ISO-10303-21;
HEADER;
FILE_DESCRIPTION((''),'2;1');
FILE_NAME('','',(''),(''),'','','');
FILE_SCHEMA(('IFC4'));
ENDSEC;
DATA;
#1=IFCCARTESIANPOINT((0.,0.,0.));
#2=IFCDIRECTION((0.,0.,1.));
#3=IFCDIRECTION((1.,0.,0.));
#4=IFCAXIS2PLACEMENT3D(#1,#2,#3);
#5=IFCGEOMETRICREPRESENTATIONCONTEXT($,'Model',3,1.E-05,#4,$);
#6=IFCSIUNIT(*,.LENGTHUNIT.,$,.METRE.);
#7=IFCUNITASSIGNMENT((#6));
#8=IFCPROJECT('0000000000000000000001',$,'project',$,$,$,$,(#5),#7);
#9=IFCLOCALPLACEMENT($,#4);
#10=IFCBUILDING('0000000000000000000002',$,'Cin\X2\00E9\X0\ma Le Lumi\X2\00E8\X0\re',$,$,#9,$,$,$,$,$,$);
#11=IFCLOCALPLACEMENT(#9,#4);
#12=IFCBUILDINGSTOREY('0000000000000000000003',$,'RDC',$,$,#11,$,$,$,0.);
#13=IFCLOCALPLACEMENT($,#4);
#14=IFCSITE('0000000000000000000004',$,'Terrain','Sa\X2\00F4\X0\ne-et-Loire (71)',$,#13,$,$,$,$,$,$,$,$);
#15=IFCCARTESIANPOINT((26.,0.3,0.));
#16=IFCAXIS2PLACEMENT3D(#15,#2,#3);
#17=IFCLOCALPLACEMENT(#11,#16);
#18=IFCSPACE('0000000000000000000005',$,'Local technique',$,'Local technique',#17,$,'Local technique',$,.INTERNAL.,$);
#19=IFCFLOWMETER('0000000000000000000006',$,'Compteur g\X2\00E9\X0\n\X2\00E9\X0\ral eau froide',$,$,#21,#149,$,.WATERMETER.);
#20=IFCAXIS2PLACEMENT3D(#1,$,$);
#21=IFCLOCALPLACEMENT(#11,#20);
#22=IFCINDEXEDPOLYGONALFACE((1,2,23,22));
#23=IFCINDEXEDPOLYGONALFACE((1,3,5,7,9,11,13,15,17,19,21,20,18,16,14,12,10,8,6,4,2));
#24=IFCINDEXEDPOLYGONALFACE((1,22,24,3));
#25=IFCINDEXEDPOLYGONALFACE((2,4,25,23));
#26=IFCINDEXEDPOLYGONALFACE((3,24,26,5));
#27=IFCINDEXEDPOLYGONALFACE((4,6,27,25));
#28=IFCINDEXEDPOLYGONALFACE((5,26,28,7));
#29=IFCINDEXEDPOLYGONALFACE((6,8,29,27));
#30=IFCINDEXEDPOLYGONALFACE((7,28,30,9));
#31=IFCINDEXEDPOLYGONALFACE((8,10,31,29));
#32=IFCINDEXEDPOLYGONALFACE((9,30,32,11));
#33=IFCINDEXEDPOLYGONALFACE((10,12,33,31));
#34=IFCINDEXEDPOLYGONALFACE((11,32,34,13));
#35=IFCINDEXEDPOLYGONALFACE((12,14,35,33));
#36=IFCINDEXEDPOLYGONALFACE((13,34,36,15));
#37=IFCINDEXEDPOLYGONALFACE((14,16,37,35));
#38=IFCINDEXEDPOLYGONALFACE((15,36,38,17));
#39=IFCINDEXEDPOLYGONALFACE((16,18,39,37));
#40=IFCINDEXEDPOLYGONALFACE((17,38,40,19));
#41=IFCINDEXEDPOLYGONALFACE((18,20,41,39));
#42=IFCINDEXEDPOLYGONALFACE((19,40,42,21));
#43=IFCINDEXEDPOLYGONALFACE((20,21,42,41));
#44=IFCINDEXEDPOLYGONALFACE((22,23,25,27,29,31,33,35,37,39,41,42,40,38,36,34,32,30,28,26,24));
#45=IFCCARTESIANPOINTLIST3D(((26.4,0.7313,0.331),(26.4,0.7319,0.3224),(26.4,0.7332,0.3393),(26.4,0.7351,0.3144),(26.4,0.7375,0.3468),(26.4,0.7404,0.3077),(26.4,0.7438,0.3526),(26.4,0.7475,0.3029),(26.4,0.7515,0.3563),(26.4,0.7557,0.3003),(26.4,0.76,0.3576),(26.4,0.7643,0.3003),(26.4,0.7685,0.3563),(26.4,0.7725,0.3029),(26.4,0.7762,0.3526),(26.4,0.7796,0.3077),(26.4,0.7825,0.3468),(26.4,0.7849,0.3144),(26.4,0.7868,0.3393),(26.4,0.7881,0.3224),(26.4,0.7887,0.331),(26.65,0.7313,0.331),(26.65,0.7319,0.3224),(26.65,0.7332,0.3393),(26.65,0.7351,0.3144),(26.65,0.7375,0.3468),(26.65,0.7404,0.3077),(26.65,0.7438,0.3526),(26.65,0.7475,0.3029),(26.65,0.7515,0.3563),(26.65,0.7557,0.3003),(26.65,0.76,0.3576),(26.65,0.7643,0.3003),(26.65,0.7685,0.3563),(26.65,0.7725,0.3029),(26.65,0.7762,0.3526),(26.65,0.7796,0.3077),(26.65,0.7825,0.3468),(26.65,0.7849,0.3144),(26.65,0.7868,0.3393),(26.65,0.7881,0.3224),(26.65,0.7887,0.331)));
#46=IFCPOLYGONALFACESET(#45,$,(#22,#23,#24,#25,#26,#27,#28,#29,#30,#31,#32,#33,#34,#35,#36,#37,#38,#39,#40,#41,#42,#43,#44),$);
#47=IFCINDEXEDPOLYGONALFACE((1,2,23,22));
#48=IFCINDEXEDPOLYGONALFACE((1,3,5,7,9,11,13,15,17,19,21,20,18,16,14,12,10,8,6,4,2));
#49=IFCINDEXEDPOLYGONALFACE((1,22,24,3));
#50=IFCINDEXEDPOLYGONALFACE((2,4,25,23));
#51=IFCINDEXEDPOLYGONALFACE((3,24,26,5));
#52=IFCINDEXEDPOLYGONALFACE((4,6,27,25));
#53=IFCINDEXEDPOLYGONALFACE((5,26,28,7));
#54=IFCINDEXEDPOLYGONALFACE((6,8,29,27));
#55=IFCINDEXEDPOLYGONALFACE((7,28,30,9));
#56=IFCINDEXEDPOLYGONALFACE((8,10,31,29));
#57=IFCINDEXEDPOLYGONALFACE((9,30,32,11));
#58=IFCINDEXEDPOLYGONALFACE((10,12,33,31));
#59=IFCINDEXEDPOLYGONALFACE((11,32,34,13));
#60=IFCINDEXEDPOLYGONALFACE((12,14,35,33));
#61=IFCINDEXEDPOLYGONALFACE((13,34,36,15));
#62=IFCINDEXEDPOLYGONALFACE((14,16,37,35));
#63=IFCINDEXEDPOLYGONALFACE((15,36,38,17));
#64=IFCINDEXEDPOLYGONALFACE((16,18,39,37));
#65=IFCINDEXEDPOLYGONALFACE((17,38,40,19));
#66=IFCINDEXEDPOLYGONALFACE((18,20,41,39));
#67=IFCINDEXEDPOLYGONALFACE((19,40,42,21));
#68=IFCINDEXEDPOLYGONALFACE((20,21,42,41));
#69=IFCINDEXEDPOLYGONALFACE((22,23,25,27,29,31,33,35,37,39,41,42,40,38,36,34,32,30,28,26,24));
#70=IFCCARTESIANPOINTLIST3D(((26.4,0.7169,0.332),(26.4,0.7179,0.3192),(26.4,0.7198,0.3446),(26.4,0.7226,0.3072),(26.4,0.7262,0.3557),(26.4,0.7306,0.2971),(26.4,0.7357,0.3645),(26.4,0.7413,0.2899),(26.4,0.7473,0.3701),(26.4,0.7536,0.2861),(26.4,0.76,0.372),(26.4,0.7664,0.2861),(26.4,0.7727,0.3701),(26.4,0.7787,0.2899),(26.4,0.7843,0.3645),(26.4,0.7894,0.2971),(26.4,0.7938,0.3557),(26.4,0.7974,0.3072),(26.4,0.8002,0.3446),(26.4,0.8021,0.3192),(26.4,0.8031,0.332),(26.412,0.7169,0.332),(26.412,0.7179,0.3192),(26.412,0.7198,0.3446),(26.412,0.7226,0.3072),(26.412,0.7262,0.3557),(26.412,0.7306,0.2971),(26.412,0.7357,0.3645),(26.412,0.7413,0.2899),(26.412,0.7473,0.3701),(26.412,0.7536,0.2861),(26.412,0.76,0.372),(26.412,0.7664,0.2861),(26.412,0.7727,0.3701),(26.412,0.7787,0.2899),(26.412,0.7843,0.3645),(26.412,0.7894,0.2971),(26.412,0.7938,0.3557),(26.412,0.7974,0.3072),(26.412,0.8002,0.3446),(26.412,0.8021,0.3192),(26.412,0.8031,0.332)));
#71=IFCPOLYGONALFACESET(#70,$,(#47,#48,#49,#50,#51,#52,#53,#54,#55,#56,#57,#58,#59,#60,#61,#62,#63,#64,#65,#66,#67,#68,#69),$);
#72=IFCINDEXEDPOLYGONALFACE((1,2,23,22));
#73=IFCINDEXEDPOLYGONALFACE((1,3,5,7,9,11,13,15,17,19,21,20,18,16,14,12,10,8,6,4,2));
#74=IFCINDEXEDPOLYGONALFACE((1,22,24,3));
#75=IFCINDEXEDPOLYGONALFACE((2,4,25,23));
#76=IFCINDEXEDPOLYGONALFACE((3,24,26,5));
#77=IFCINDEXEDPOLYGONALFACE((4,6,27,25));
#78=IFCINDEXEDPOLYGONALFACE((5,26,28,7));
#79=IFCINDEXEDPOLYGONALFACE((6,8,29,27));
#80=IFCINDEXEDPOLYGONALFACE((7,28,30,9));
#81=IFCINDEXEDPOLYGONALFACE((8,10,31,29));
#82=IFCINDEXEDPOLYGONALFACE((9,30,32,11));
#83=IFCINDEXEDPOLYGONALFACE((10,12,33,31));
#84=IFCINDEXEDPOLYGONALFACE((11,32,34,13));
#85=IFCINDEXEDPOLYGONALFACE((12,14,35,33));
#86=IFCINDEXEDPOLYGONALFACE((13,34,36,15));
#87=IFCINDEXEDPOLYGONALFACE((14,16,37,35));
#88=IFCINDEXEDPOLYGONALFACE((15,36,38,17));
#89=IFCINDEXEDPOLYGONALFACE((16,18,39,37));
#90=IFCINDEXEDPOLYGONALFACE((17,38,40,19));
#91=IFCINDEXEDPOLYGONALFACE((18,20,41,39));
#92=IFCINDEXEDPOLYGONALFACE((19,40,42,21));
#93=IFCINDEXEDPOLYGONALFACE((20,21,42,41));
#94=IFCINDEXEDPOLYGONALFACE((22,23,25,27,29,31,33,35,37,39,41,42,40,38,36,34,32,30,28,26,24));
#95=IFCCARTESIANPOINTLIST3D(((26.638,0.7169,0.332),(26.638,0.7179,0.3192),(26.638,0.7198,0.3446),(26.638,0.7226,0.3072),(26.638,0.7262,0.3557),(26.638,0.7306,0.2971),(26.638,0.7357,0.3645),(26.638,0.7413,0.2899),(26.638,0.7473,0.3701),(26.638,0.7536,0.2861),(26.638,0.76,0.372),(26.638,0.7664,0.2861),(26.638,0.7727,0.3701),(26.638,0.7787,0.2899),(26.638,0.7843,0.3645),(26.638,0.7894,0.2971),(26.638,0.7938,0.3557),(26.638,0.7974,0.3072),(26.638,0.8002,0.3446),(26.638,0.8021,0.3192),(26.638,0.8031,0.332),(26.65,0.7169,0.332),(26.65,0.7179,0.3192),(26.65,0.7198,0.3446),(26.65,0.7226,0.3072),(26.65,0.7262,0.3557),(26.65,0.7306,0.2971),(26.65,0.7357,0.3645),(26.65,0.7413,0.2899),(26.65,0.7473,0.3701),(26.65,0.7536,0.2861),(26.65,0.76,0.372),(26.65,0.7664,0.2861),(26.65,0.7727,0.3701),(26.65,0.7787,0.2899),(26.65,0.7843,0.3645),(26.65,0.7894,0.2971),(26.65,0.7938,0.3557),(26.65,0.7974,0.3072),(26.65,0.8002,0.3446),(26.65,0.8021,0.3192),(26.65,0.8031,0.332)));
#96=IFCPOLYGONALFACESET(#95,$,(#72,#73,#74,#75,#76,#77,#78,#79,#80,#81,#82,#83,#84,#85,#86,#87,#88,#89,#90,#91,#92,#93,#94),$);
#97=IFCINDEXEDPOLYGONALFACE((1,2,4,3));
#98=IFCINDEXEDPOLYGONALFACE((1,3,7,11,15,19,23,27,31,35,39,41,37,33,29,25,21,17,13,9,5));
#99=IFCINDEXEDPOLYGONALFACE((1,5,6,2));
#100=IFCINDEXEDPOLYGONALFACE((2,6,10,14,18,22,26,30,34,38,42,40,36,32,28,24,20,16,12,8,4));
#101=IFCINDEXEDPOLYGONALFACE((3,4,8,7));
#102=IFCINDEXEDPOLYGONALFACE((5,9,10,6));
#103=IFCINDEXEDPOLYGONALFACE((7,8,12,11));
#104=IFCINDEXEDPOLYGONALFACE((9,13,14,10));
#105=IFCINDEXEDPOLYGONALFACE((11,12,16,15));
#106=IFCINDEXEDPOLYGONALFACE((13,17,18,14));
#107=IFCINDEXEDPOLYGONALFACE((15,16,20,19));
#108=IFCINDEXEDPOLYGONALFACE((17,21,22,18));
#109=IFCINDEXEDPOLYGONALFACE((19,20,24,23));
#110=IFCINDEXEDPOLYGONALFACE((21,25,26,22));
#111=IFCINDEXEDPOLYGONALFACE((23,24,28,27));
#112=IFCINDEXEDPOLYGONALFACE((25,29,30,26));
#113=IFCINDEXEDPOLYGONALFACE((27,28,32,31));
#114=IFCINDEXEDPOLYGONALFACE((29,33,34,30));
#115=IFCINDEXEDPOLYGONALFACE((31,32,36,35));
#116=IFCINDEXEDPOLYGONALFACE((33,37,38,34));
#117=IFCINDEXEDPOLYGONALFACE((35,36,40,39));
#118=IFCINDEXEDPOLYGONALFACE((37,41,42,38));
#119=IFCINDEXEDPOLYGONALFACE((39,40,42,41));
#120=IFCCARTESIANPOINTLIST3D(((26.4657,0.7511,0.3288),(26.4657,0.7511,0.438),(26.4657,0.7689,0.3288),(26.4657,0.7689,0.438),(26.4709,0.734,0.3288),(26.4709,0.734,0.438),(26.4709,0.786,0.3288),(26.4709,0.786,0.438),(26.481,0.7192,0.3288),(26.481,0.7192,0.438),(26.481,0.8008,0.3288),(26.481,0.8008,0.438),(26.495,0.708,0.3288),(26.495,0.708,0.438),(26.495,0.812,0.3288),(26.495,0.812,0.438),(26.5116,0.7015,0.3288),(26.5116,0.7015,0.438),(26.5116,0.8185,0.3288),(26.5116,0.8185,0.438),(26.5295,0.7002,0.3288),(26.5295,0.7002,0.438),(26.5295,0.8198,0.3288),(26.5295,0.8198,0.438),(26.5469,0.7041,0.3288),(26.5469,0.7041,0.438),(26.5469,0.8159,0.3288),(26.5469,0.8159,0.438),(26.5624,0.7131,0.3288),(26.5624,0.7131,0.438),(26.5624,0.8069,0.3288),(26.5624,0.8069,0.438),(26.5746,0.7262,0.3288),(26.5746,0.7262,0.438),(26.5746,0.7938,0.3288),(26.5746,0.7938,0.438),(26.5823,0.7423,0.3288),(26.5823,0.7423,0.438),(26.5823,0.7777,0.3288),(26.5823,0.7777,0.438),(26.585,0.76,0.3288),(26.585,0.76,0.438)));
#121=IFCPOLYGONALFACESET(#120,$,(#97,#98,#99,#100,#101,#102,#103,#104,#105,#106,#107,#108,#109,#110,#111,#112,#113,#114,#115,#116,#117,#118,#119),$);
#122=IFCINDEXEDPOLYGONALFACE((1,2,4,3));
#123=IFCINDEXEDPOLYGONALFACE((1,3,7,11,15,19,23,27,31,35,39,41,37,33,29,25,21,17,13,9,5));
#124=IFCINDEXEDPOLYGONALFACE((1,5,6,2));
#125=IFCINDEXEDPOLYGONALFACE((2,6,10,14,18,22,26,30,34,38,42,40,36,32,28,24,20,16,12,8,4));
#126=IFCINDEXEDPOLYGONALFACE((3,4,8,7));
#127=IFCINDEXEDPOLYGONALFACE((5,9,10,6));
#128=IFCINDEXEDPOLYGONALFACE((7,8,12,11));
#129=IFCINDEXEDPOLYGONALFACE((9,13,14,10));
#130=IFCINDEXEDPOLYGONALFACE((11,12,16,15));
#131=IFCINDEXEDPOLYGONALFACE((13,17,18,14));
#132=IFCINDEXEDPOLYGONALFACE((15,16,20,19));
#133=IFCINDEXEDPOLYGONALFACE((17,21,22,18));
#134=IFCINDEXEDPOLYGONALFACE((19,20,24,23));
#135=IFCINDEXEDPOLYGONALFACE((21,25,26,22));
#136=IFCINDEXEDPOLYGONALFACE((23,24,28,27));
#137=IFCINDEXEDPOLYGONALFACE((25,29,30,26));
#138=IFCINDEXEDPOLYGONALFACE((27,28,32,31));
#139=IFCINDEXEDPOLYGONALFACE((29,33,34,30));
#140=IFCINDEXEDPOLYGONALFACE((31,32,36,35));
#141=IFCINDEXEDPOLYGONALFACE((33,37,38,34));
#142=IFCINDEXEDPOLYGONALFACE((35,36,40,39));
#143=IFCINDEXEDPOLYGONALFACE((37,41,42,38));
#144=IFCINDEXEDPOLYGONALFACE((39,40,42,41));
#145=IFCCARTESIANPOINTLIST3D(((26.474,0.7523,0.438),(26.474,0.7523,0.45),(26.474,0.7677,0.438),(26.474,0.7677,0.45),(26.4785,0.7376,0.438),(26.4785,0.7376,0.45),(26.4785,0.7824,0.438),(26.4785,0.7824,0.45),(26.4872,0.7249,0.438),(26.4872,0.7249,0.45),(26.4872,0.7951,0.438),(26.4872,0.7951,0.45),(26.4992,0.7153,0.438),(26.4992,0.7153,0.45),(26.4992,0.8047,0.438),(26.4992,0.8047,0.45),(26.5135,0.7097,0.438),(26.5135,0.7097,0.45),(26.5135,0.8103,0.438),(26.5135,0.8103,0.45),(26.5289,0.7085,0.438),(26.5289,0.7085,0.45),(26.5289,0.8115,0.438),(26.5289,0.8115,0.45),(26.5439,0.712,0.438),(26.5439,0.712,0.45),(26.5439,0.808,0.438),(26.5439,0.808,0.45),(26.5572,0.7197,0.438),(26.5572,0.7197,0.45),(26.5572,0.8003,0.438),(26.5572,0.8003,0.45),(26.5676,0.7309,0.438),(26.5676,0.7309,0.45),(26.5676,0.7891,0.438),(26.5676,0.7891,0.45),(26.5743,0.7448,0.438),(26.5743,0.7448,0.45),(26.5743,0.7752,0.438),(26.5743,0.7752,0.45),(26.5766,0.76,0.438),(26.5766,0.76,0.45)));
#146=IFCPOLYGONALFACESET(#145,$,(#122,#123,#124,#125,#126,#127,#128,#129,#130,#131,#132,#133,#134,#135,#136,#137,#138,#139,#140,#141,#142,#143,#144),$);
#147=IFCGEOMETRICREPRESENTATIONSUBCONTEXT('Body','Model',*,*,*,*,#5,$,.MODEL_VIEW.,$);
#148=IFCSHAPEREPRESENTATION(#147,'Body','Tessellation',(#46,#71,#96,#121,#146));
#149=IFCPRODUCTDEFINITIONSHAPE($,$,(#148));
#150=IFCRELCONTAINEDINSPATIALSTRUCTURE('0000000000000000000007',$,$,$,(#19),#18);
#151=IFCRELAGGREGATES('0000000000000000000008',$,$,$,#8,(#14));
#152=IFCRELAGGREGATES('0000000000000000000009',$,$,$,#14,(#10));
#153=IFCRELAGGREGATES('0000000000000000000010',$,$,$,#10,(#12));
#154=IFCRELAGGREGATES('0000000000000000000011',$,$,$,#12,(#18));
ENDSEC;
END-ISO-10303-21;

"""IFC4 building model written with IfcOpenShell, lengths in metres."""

from ifc_helpers import new_model, si_unit, frame, origin_with_axes, place, context, subcontext, project, spatial, circle, extrude, element, save


model = new_model("IFC4")

# Units and contexts
model_context = context("Model", 3, precision=1e-05, world=origin_with_axes())
body_context = subcontext(model_context, "Body", "Model", "MODEL_VIEW")
ifc_project = project(units=[si_unit("LENGTHUNIT", "METRE")], contexts=[model_context])

# Site, building, storey
site_placement = place(None, origin_with_axes())
site = spatial("IfcSite", under=ifc_project, at=site_placement, Name="Terrain", Description="Saône-et-Loire (71)")
building_placement = place(None, origin_with_axes())
building = spatial("IfcBuilding", under=site, at=building_placement, Name="Cinéma Le Lumière")
storey_placement = place(building_placement, origin_with_axes())
storey = spatial("IfcBuildingStorey", under=building, at=storey_placement, Name="RDC", Elevation=0.0)

# Shared definitions
space_1_placement = place(storey_placement, frame((26.0, 0.3, 0.0), z_axis=(0.0, 0.0, 1.0), x_axis=(1.0, 0.0, 0.0)))
space_1 = spatial("IfcSpace", under=storey, at=space_1_placement, Name="Local technique", ObjectType="Local technique", LongName="Local technique", PredefinedType="INTERNAL")

# Flow meter
flow_meter_placement = place(space_1_placement, frame((0.4, 0.4, 0.3), z_axis=(0.0, 0.0, 1.0), x_axis=(1.0, 0.0, 0.0)))
element("IfcFlowMeter", 1, at=flow_meter_placement, inside=space_1, Name="Compteur général eau froide", PredefinedType="WATERMETER", context=body_context, shape_type="SweptSolid", body=[
    extrude(circle(Radius=0.0288), frame((0.0, 0.06, 0.0288), z_axis=(1.0, 0.0, 0.0), x_axis=(0.0, 0.0, 1.0)), (0.0, 0.0, 1.0), 0.25),
    extrude(circle(Radius=0.0432), frame((0.0, 0.06, 0.0288), z_axis=(1.0, 0.0, 0.0), x_axis=(0.0, 0.0, 1.0)), (0.0, 0.0, 1.0), 0.012),
    extrude(circle(Radius=0.0432), frame((0.238, 0.06, 0.0288), z_axis=(1.0, 0.0, 0.0), x_axis=(0.0, 0.0, 1.0)), (0.0, 0.0, 1.0), 0.012),
    extrude(circle(Radius=0.06), frame((0.125, 0.06, 0.0288), z_axis=(0.0, 0.0, 1.0), x_axis=(1.0, 0.0, 0.0)), (0.0, 0.0, 1.0), 0.1092),
    extrude(circle(Radius=0.0516), frame((0.125, 0.06, 0.138), z_axis=(0.0, 0.0, 1.0), x_axis=(1.0, 0.0, 0.0)), (0.0, 0.0, 1.0), 0.012),
])

save(model, "model.ifc")
